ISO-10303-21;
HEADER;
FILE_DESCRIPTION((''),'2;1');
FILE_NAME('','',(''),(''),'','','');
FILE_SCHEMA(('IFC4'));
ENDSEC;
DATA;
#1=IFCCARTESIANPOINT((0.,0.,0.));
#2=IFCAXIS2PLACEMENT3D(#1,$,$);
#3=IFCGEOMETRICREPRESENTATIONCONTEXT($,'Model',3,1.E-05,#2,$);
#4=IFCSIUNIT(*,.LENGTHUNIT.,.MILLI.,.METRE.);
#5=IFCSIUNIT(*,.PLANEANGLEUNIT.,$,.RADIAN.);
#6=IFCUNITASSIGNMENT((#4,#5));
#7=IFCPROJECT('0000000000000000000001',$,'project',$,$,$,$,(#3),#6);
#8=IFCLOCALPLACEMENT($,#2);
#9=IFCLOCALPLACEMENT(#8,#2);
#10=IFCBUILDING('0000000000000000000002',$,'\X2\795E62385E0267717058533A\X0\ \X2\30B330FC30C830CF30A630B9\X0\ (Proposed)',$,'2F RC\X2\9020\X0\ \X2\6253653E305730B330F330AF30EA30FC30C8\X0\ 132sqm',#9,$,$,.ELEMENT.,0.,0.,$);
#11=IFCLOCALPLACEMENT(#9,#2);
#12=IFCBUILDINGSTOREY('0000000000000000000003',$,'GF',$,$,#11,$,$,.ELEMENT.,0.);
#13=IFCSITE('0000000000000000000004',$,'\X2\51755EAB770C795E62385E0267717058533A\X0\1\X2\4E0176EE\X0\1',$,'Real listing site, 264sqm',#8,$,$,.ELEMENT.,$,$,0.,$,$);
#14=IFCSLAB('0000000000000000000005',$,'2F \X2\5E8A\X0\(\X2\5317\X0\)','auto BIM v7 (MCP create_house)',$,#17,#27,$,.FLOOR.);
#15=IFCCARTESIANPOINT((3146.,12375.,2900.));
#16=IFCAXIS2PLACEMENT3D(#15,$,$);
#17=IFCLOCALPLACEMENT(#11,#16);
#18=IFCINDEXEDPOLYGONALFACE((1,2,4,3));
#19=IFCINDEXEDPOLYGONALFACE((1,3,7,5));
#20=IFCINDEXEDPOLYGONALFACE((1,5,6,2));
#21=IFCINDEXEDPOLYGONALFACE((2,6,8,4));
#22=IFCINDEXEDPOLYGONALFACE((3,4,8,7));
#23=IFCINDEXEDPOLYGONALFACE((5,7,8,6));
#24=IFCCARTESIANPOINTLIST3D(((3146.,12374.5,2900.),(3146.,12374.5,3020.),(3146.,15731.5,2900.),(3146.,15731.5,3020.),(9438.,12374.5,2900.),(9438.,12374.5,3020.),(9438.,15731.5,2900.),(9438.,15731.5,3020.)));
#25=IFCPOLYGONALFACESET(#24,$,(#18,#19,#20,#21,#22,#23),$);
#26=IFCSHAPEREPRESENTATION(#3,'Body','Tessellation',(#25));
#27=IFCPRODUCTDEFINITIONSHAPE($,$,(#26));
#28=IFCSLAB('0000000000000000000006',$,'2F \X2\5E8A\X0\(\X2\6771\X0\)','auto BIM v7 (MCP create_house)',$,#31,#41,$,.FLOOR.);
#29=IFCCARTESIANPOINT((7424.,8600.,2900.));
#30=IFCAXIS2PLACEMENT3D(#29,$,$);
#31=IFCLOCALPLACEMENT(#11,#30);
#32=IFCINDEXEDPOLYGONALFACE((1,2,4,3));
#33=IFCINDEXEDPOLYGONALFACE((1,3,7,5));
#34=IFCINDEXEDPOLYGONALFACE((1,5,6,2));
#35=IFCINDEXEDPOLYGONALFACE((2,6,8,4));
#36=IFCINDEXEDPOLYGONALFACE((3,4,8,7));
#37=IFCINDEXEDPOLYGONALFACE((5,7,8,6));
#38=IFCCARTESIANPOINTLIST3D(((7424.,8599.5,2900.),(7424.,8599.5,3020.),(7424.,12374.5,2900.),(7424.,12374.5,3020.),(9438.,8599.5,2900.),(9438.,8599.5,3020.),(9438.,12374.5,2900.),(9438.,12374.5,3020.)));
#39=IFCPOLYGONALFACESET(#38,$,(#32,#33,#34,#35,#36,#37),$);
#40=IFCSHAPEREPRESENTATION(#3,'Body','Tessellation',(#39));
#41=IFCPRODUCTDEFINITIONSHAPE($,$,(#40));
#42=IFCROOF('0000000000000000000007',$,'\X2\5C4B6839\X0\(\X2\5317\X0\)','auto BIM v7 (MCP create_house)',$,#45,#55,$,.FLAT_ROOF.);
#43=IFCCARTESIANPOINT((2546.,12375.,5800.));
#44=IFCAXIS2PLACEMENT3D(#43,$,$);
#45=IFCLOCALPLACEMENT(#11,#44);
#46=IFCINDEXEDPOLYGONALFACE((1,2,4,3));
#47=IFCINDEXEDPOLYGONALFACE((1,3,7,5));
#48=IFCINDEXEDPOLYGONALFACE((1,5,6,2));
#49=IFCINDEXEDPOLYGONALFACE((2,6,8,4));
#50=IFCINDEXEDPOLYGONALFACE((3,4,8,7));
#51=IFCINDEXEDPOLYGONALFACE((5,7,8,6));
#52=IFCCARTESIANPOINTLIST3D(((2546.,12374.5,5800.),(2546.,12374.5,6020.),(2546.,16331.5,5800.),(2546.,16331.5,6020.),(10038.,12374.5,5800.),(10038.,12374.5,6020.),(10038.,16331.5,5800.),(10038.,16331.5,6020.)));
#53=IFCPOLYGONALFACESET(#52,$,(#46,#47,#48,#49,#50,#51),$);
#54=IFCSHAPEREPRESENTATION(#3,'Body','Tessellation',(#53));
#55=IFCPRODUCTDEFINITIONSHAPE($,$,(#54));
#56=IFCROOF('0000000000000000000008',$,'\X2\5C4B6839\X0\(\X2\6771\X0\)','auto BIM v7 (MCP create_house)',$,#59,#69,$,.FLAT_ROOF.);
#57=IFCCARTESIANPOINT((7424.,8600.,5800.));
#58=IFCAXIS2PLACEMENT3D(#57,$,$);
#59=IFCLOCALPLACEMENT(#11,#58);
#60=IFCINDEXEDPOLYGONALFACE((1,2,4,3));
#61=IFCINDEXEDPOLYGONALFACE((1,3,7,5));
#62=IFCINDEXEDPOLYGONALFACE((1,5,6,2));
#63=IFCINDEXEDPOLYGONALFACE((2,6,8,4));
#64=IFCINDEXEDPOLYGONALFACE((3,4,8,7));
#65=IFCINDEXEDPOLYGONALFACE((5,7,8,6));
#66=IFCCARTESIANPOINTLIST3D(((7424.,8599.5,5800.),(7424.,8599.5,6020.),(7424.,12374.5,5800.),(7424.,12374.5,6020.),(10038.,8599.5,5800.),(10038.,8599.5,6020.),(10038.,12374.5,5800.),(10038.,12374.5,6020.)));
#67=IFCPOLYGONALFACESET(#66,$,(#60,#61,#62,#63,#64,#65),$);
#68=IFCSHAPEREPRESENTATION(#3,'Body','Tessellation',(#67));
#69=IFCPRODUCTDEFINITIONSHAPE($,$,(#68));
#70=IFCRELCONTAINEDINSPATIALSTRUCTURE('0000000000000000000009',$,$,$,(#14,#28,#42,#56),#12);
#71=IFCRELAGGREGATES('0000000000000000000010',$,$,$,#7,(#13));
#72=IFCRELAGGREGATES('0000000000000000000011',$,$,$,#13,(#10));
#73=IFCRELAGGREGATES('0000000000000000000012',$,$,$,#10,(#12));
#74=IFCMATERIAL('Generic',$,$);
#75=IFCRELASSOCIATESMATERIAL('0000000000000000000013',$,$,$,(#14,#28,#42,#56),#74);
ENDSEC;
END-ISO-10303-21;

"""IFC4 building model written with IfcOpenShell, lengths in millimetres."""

from ifc_helpers import new_model, si_unit, frame, frame_2d, origin, place, context, project, spatial, rectangle, extrude, material, element, save


model = new_model("IFC4")

# Units and contexts
model_context = context("Model", 3, precision=1e-05, world=origin())
ifc_project = project(units=[si_unit("LENGTHUNIT", "METRE", prefix="MILLI"), si_unit("PLANEANGLEUNIT", "RADIAN")], contexts=[model_context])

# Site, building, storey
site_placement = place(None, origin())
site = spatial("IfcSite", under=ifc_project, at=site_placement, Name="兵庫県神戸市東灘区1丁目1", ObjectType="Real listing site, 264sqm", CompositionType="ELEMENT", RefElevation=0.0)
building_placement = place(site_placement, origin())
building = spatial("IfcBuilding", under=site, at=building_placement, Name="神戸市東灘区 コートハウス (Proposed)", ObjectType="2F RC造 打放しコンクリート 132sqm", CompositionType="ELEMENT", ElevationOfRefHeight=0.0, ElevationOfTerrain=0.0)
storey_placement = place(building_placement, origin())
storey = spatial("IfcBuildingStorey", under=building, at=storey_placement, Name="GF", CompositionType="ELEMENT", Elevation=0.0)

# Slabs
ifc_material = material(Name="Generic")
slab_1_placement = place(storey_placement, frame((3146.0, 12375.0, 2900.0)))
element("IfcSlab", 1, at=slab_1_placement, inside=storey, material=ifc_material, Name="2F 床(北)", Description="auto BIM v7 (MCP create_house)", PredefinedType="FLOOR", context=model_context, shape_type="SweptSolid", body=[
    extrude(rectangle(XDim=6292.0, YDim=3357.0, at=frame_2d((3146.0, 1678.0))), frame((3146.0, 12375.0, 2900.0)), (0.0, 0.0, 1.0), 120.0),
])
slab_2_placement = place(storey_placement, frame((7424.0, 8600.0, 2900.0)))
element("IfcSlab", 2, at=slab_2_placement, inside=storey, material=ifc_material, Name="2F 床(東)", Description="auto BIM v7 (MCP create_house)", PredefinedType="FLOOR", context=model_context, shape_type="SweptSolid", body=[
    extrude(rectangle(XDim=2014.0, YDim=3775.0, at=frame_2d((1007.0, 1887.0))), frame((7424.0, 8600.0, 2900.0)), (0.0, 0.0, 1.0), 120.0),
])

# Roofs
roof_1_placement = place(storey_placement, frame((2546.0, 12375.0, 5800.0)))
element("IfcRoof", 3, at=roof_1_placement, inside=storey, material=ifc_material, Name="屋根(北)", Description="auto BIM v7 (MCP create_house)", PredefinedType="FLAT_ROOF", context=model_context, shape_type="SweptSolid", body=[
    extrude(rectangle(XDim=7492.0, YDim=3957.0, at=frame_2d((3746.0, 1978.0))), frame((2546.0, 12375.0, 5800.0)), (0.0, 0.0, 1.0), 220.0),
])
roof_2_placement = place(storey_placement, frame((7424.0, 8600.0, 5800.0)))
element("IfcRoof", 4, at=roof_2_placement, inside=storey, material=ifc_material, Name="屋根(東)", Description="auto BIM v7 (MCP create_house)", PredefinedType="FLAT_ROOF", context=model_context, shape_type="SweptSolid", body=[
    extrude(rectangle(XDim=2614.0, YDim=3775.0, at=frame_2d((1307.0, 1887.0))), frame((7424.0, 8600.0, 5800.0)), (0.0, 0.0, 1.0), 220.0),
])

save(model, "model.ifc")
